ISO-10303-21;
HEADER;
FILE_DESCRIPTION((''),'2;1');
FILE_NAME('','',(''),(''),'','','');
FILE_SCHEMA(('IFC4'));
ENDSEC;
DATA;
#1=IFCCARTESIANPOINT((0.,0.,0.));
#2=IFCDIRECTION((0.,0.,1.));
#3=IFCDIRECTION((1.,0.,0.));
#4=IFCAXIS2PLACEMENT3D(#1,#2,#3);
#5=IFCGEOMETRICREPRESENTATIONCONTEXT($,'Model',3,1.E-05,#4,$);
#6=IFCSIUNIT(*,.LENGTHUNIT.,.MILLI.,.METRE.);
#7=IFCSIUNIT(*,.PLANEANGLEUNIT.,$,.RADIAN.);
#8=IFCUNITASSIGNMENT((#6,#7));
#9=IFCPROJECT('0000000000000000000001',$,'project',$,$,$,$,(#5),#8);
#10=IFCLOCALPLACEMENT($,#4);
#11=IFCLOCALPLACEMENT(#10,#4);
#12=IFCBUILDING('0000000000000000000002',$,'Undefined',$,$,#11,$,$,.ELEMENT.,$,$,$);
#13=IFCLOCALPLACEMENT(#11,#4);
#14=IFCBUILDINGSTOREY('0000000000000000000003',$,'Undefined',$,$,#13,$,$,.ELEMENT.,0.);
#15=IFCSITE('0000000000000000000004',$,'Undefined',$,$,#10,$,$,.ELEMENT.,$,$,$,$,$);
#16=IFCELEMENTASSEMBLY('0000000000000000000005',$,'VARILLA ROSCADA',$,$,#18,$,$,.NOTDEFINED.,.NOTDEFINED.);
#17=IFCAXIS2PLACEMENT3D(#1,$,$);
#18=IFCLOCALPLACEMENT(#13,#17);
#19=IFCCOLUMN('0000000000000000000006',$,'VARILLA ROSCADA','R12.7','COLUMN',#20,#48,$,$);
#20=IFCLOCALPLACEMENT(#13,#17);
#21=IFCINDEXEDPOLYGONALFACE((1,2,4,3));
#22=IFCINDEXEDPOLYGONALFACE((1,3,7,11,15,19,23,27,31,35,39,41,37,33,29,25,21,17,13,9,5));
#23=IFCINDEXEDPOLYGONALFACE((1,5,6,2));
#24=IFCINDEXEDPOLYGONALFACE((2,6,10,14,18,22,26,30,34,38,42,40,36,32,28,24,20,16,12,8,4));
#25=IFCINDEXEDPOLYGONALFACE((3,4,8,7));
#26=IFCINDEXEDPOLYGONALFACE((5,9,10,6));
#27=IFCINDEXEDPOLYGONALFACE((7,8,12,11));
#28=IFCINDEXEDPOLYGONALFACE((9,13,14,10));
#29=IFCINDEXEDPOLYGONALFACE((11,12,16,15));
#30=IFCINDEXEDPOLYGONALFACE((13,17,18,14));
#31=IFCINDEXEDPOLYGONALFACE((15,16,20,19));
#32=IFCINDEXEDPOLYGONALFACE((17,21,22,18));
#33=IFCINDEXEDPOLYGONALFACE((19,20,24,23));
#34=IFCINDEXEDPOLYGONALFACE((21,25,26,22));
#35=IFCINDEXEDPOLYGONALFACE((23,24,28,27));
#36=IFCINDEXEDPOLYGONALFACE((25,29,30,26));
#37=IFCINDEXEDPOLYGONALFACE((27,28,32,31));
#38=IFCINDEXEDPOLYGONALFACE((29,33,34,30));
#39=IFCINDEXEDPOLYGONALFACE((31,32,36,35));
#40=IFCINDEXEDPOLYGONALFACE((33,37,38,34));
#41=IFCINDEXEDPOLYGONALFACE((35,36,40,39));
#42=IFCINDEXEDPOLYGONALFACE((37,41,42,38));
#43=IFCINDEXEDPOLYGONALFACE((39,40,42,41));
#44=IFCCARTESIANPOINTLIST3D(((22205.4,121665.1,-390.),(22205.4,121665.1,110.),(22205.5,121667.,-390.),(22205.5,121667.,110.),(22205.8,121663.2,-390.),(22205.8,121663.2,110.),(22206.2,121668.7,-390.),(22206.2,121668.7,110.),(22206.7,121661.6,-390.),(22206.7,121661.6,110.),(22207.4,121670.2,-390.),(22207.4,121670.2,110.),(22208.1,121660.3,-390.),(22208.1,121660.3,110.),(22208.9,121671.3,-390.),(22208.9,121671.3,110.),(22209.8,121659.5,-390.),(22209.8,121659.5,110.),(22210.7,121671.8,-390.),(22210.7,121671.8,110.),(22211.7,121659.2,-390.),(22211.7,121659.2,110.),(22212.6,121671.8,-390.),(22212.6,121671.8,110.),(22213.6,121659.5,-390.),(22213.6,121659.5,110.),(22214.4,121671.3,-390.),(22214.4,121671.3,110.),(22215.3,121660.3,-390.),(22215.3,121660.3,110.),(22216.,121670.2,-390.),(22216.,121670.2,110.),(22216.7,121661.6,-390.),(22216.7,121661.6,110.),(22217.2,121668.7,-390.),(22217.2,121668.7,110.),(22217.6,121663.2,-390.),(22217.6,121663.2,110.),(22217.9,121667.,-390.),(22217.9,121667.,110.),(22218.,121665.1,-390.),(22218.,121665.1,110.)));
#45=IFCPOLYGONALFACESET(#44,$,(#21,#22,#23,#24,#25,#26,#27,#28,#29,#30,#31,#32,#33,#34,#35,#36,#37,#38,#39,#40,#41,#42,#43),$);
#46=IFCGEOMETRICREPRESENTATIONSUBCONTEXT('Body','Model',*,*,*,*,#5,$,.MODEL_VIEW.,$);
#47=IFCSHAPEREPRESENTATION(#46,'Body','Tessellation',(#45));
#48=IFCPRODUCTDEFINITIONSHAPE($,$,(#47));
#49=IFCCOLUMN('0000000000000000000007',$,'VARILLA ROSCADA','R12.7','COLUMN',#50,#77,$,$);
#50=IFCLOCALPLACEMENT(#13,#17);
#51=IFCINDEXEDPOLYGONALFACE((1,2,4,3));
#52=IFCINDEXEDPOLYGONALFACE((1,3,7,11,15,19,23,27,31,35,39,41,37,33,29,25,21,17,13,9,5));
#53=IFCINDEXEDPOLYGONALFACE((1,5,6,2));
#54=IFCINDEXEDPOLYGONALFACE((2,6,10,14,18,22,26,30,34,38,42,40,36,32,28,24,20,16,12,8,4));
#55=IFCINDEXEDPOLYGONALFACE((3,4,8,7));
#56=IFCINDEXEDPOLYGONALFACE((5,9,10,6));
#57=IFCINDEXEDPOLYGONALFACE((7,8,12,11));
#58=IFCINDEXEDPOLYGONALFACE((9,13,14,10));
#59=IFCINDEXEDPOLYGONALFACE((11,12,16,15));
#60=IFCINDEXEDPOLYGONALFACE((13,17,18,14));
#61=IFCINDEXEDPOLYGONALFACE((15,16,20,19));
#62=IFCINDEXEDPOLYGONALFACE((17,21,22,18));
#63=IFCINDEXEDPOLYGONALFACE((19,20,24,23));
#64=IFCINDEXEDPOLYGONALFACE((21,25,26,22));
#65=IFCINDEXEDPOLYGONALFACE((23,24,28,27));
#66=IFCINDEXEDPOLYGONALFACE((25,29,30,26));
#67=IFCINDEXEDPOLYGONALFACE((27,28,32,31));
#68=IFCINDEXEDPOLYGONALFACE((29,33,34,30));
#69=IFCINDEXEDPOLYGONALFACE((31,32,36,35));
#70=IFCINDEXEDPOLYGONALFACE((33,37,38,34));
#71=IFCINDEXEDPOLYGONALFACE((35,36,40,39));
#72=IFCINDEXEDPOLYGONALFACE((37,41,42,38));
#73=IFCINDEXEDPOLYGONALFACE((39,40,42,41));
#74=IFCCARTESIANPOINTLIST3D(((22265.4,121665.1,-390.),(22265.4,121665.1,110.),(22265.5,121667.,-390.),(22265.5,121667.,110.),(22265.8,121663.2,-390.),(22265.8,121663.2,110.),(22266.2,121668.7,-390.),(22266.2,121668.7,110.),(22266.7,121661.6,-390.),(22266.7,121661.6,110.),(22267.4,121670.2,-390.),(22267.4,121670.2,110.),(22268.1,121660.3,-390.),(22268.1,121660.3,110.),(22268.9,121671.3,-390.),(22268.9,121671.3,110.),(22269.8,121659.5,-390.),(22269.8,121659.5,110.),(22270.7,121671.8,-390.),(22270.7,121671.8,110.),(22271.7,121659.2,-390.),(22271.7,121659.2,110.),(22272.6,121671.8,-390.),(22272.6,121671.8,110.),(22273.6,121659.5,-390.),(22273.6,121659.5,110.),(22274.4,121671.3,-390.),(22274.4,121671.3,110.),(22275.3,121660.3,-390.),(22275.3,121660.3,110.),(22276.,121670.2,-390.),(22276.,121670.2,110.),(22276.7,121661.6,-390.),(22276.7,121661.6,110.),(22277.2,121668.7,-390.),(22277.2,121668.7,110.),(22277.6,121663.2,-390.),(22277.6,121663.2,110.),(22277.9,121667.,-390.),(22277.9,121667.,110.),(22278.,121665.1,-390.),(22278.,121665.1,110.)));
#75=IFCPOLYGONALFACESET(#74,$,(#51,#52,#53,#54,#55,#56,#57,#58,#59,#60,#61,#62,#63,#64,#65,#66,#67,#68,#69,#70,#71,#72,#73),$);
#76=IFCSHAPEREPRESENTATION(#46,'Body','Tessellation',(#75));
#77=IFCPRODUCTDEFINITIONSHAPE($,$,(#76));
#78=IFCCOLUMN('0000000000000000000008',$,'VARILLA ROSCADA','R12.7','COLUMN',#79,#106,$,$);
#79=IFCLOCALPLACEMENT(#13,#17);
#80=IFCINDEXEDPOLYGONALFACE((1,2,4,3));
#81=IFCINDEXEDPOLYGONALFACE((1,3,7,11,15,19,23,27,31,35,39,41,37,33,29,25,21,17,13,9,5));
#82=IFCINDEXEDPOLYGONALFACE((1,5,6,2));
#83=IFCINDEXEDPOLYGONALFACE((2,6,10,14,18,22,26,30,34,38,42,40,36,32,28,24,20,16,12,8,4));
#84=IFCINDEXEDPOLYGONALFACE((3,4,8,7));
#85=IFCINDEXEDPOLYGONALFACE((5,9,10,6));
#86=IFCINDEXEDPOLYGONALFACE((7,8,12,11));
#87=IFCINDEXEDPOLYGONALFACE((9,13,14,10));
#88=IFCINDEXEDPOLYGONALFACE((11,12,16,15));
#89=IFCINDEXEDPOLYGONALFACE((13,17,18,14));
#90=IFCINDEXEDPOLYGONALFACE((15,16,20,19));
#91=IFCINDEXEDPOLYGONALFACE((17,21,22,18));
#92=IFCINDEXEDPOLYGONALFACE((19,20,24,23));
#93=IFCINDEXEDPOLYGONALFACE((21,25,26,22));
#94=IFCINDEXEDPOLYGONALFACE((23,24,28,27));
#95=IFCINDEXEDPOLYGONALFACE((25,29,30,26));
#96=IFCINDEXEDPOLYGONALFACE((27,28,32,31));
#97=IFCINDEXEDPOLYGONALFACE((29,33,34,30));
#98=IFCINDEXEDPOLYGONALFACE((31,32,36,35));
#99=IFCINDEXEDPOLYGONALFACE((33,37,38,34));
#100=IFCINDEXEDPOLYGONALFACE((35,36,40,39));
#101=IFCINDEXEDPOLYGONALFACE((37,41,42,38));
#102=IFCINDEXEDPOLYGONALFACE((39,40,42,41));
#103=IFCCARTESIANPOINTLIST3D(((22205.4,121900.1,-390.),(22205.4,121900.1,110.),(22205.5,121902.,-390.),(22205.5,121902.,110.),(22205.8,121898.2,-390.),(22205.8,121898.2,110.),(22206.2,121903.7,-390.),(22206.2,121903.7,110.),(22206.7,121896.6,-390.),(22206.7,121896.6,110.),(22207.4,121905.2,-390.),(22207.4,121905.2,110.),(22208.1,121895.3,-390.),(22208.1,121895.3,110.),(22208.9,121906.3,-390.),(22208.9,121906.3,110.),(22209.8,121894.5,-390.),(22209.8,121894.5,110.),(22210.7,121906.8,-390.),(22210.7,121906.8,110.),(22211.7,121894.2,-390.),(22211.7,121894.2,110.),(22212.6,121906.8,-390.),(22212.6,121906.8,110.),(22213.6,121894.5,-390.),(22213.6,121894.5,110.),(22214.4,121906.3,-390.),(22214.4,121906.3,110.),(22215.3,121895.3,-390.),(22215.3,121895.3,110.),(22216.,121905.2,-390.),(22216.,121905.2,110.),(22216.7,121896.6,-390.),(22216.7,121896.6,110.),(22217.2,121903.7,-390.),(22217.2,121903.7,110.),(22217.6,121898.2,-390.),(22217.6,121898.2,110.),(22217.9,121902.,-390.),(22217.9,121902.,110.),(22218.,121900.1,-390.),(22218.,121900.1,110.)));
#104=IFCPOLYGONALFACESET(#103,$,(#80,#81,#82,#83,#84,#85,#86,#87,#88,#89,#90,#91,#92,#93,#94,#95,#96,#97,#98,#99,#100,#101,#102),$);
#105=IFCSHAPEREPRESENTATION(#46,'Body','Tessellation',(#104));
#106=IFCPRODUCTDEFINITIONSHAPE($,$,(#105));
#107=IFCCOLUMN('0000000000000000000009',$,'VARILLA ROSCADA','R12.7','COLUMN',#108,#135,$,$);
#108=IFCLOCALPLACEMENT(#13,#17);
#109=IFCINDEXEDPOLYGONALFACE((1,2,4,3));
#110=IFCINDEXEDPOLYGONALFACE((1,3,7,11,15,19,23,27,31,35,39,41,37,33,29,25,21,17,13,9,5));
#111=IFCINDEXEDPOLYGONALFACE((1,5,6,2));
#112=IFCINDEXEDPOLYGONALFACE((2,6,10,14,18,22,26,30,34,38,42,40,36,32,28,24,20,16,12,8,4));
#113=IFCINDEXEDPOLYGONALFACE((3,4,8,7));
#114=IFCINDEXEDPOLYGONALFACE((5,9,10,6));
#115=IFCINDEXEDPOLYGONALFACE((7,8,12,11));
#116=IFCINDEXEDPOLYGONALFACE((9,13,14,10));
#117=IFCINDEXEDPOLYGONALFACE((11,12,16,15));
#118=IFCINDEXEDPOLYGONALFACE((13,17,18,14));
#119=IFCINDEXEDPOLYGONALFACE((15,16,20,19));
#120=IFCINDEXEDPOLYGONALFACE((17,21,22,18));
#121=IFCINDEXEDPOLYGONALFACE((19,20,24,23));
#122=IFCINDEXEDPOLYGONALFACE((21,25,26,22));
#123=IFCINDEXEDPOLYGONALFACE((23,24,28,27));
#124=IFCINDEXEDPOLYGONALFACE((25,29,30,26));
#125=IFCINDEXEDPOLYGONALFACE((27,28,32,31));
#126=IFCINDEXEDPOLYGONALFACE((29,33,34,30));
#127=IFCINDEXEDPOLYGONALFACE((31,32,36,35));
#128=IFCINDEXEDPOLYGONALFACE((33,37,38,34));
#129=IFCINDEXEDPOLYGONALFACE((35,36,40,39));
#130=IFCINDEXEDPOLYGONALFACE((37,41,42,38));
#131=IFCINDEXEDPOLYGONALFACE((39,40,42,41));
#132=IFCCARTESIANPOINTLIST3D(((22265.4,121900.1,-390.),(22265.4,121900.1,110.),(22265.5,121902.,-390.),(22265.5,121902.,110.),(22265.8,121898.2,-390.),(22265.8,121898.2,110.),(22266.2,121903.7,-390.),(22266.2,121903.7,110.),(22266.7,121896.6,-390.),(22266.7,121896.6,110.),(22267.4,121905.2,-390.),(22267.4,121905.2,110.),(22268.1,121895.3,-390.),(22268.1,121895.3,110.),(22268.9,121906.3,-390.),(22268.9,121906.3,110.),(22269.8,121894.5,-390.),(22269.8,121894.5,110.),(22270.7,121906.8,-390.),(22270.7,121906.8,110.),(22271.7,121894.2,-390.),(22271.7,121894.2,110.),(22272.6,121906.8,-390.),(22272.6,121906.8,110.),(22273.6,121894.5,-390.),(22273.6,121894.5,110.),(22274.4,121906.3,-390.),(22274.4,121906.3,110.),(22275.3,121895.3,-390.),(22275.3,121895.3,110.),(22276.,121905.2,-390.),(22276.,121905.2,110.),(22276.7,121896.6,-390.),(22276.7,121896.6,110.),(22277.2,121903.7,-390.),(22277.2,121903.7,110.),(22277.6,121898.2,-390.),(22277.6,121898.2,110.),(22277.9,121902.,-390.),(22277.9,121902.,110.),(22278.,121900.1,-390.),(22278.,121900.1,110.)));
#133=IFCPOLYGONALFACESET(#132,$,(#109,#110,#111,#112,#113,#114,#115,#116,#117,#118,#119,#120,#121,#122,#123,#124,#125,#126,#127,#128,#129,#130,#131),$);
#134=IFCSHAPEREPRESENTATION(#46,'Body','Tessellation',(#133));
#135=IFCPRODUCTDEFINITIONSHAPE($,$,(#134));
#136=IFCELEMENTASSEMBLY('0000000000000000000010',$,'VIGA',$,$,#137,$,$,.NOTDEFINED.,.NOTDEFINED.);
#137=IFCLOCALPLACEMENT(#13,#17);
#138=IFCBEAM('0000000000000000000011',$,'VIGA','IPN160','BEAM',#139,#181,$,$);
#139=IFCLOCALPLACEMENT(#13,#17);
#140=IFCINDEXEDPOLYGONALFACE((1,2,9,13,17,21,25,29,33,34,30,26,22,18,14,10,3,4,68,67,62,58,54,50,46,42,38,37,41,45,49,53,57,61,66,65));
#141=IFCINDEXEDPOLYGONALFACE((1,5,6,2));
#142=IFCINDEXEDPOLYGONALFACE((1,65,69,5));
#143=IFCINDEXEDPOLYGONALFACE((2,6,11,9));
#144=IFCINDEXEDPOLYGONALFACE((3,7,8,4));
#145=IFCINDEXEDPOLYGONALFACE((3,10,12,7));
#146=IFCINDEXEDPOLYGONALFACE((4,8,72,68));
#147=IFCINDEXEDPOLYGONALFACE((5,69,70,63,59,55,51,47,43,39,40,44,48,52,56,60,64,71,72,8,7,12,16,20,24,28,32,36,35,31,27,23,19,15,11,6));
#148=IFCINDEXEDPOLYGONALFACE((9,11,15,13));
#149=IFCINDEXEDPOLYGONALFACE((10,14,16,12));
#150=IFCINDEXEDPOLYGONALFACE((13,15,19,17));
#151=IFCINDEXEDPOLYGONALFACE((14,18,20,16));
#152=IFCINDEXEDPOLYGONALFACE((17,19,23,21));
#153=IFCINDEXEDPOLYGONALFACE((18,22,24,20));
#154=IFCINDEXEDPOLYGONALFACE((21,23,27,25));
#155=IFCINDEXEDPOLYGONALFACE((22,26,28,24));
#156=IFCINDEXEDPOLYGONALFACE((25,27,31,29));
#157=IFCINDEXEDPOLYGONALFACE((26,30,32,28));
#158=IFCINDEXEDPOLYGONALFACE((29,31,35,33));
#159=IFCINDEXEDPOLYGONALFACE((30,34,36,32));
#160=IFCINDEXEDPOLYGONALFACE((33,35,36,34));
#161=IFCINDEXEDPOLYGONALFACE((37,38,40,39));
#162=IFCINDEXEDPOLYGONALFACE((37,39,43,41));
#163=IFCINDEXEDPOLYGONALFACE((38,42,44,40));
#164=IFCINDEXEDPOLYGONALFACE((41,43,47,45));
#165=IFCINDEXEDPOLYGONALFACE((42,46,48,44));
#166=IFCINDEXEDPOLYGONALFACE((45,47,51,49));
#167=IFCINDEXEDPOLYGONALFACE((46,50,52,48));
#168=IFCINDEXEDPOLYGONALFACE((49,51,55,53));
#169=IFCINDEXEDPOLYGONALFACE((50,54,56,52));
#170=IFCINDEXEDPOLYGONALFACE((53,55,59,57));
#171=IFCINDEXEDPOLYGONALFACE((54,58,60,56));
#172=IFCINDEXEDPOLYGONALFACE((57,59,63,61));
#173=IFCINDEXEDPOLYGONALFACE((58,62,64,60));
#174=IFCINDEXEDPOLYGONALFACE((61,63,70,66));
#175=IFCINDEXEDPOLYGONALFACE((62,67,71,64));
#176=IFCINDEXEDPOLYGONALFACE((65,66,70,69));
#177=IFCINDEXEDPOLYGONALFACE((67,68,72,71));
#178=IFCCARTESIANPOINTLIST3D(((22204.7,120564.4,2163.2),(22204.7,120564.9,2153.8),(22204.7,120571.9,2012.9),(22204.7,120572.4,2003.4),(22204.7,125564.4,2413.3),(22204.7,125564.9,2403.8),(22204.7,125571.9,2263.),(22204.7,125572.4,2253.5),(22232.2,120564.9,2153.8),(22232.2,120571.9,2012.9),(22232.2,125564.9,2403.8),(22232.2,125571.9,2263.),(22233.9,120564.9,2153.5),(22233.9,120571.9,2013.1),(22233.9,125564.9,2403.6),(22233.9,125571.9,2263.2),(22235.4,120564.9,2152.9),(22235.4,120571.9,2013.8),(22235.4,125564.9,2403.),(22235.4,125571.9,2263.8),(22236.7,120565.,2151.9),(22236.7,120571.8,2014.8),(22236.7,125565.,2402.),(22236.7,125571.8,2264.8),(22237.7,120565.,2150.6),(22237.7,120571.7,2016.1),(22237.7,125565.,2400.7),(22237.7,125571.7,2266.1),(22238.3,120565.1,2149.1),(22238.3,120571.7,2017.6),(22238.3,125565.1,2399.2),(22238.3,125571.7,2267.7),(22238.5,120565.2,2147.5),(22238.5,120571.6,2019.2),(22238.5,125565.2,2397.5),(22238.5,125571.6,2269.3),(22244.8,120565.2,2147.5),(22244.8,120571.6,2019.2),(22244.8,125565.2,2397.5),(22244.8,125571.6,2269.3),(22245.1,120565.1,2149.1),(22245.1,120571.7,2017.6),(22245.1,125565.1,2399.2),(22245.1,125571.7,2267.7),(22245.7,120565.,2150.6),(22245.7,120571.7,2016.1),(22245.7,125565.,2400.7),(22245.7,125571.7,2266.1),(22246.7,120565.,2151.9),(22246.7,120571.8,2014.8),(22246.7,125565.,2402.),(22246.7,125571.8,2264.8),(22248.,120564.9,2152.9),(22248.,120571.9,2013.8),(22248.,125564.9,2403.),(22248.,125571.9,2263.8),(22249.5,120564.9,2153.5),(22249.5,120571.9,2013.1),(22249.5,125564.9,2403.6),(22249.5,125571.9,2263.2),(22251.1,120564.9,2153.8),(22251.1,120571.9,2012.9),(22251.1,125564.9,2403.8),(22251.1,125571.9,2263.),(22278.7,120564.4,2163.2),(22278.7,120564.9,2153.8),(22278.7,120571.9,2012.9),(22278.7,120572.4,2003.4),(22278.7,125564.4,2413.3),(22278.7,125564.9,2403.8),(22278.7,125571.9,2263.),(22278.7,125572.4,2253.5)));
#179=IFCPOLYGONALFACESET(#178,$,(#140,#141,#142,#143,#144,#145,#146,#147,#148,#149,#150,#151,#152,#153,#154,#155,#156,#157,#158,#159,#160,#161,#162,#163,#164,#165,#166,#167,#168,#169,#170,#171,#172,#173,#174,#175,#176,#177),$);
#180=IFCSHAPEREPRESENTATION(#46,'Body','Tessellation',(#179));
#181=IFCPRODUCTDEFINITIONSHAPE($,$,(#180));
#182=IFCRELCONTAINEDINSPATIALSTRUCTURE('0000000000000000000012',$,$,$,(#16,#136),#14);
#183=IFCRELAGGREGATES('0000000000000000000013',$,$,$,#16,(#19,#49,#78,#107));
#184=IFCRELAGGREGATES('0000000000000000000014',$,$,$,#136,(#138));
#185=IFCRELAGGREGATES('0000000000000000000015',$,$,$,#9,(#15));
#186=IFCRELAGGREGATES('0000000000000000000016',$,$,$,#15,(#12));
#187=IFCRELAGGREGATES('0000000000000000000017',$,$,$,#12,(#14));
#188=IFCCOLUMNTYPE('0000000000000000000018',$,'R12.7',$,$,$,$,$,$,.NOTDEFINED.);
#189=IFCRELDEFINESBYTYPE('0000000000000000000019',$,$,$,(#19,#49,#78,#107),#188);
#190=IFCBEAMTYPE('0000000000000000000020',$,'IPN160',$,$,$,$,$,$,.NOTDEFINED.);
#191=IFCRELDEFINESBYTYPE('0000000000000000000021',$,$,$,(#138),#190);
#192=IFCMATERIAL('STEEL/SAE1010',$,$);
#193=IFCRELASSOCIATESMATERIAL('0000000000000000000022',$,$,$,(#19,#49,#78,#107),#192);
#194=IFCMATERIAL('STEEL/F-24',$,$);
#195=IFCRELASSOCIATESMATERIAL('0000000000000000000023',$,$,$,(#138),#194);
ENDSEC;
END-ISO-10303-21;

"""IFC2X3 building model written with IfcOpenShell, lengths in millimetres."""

from ifc_helpers import new_model, si_unit, frame, origin_with_axes, origin_2d_with_axis, place, context, subcontext, project, spatial, circle, i_section, extrude, material, type_object, element, aggregate, save


model = new_model("IFC2X3")

# Units and contexts
model_context = context("Model", 3, precision=1e-05, world=origin_with_axes())
body_context = subcontext(model_context, "Body", "Model", "MODEL_VIEW")
ifc_project = project(units=[si_unit("LENGTHUNIT", "METRE", prefix="MILLI"), si_unit("PLANEANGLEUNIT", "RADIAN")], contexts=[model_context])

# Site, building, storey
site_placement = place(None, origin_with_axes())
site = spatial("IfcSite", under=ifc_project, at=site_placement, Name="Undefined", CompositionType="ELEMENT")
building_placement = place(site_placement, origin_with_axes())
building = spatial("IfcBuilding", under=site, at=building_placement, Name="Undefined", CompositionType="ELEMENT")
storey_placement = place(building_placement, origin_with_axes())
storey = spatial("IfcBuildingStorey", under=building, at=storey_placement, Name="Undefined", CompositionType="ELEMENT", Elevation=0.0)

# Element assembly, columns
assembly_1_placement = place(storey_placement, origin_with_axes())
assembly_1 = element("IfcElementAssembly", 1, at=assembly_1_placement, inside=storey, Name="VARILLA ROSCADA", AssemblyPlace="NOTDEFINED", PredefinedType="NOTDEFINED")
ifc_material_1 = material(Name="STEEL/SAE1010")
column_type = type_object("IfcColumnType", Name="R12.7", PredefinedType="NOTDEFINED")
column_1_placement = place(assembly_1_placement, frame((22211.7, 121665.6, -390.0), z_axis=(0.0, 0.0, 1.0), x_axis=(-1.0, 0.0, 0.0)))
column_1 = element("IfcColumn", 2, at=column_1_placement, type_object=column_type, material=ifc_material_1, Name="VARILLA ROSCADA", Description="R12.7", ObjectType="COLUMN", context=body_context, shape_type="SweptSolid", body=[
    extrude(circle(Radius=6.3, at=origin_2d_with_axis()), frame((0.0, 0.0, 500.0), z_axis=(0.0, 0.0, -1.0), x_axis=(0.0, 1.0, 0.0)), (0.0, 0.0, 1.0), 500.0),
])
column_2_placement = place(assembly_1_placement, frame((22271.7, 121665.6, -390.0), z_axis=(0.0, 0.0, 1.0), x_axis=(-1.0, 0.0, 0.0)))
column_2 = element("IfcColumn", 3, at=column_2_placement, type_object=column_type, material=ifc_material_1, Name="VARILLA ROSCADA", Description="R12.7", ObjectType="COLUMN", context=body_context, shape_type="SweptSolid", body=[
    extrude(circle(Radius=6.3, at=origin_2d_with_axis()), frame((0.0, 0.0, 500.0), z_axis=(0.0, 0.0, -1.0), x_axis=(0.0, 1.0, 0.0)), (0.0, 0.0, 1.0), 500.0),
])
column_3_placement = place(assembly_1_placement, frame((22211.7, 121900.6, -390.0), z_axis=(0.0, 0.0, 1.0), x_axis=(-1.0, 0.0, 0.0)))
column_3 = element("IfcColumn", 4, at=column_3_placement, type_object=column_type, material=ifc_material_1, Name="VARILLA ROSCADA", Description="R12.7", ObjectType="COLUMN", context=body_context, shape_type="SweptSolid", body=[
    extrude(circle(Radius=6.3, at=origin_2d_with_axis()), frame((0.0, 0.0, 500.0), z_axis=(0.0, 0.0, -1.0), x_axis=(0.0, 1.0, 0.0)), (0.0, 0.0, 1.0), 500.0),
])
column_4_placement = place(assembly_1_placement, frame((22271.7, 121900.6, -390.0), z_axis=(0.0, 0.0, 1.0), x_axis=(-1.0, 0.0, 0.0)))
column_4 = element("IfcColumn", 5, at=column_4_placement, type_object=column_type, material=ifc_material_1, Name="VARILLA ROSCADA", Description="R12.7", ObjectType="COLUMN", context=body_context, shape_type="SweptSolid", body=[
    extrude(circle(Radius=6.3, at=origin_2d_with_axis()), frame((0.0, 0.0, 500.0), z_axis=(0.0, 0.0, -1.0), x_axis=(0.0, 1.0, 0.0)), (0.0, 0.0, 1.0), 500.0),
])

# Element assembly, beam
assembly_2_placement = place(storey_placement, origin_with_axes())
assembly_2 = element("IfcElementAssembly", 6, at=assembly_2_placement, inside=storey, Name="VIGA", AssemblyPlace="NOTDEFINED", PredefinedType="NOTDEFINED")
ifc_material_2 = material(Name="STEEL/F-24")
beam_type_1 = type_object("IfcBeamType", Name="IPN160", PredefinedType="NOTDEFINED")
beam_1_placement = place(assembly_2_placement, frame((22241.7, 120568.4, 2083.3), z_axis=(0.0, -0.04995, 0.998752), x_axis=(0.0, 0.998752, 0.04995)))
beam_1 = element("IfcBeam", 7, at=beam_1_placement, type_object=beam_type_1, material=ifc_material_2, Name="VIGA", Description="IPN160", ObjectType="BEAM", context=body_context, shape_type="SweptSolid", body=[
    extrude(i_section(OverallWidth=74.0, OverallDepth=160.0, WebThickness=6.3, FlangeThickness=9.5, FilletRadius=6.3, at=origin_2d_with_axis()), frame((5006.2, 0.0, 0.0), z_axis=(-1.0, 0.0, 0.0), x_axis=(0.0, -1.0, 0.0)), (0.0, 0.0, 1.0), 5006.2),
])

aggregate(assembly_1, [column_1, column_2, column_3, column_4])
aggregate(assembly_2, [beam_1])

save(model, "model.ifc")
